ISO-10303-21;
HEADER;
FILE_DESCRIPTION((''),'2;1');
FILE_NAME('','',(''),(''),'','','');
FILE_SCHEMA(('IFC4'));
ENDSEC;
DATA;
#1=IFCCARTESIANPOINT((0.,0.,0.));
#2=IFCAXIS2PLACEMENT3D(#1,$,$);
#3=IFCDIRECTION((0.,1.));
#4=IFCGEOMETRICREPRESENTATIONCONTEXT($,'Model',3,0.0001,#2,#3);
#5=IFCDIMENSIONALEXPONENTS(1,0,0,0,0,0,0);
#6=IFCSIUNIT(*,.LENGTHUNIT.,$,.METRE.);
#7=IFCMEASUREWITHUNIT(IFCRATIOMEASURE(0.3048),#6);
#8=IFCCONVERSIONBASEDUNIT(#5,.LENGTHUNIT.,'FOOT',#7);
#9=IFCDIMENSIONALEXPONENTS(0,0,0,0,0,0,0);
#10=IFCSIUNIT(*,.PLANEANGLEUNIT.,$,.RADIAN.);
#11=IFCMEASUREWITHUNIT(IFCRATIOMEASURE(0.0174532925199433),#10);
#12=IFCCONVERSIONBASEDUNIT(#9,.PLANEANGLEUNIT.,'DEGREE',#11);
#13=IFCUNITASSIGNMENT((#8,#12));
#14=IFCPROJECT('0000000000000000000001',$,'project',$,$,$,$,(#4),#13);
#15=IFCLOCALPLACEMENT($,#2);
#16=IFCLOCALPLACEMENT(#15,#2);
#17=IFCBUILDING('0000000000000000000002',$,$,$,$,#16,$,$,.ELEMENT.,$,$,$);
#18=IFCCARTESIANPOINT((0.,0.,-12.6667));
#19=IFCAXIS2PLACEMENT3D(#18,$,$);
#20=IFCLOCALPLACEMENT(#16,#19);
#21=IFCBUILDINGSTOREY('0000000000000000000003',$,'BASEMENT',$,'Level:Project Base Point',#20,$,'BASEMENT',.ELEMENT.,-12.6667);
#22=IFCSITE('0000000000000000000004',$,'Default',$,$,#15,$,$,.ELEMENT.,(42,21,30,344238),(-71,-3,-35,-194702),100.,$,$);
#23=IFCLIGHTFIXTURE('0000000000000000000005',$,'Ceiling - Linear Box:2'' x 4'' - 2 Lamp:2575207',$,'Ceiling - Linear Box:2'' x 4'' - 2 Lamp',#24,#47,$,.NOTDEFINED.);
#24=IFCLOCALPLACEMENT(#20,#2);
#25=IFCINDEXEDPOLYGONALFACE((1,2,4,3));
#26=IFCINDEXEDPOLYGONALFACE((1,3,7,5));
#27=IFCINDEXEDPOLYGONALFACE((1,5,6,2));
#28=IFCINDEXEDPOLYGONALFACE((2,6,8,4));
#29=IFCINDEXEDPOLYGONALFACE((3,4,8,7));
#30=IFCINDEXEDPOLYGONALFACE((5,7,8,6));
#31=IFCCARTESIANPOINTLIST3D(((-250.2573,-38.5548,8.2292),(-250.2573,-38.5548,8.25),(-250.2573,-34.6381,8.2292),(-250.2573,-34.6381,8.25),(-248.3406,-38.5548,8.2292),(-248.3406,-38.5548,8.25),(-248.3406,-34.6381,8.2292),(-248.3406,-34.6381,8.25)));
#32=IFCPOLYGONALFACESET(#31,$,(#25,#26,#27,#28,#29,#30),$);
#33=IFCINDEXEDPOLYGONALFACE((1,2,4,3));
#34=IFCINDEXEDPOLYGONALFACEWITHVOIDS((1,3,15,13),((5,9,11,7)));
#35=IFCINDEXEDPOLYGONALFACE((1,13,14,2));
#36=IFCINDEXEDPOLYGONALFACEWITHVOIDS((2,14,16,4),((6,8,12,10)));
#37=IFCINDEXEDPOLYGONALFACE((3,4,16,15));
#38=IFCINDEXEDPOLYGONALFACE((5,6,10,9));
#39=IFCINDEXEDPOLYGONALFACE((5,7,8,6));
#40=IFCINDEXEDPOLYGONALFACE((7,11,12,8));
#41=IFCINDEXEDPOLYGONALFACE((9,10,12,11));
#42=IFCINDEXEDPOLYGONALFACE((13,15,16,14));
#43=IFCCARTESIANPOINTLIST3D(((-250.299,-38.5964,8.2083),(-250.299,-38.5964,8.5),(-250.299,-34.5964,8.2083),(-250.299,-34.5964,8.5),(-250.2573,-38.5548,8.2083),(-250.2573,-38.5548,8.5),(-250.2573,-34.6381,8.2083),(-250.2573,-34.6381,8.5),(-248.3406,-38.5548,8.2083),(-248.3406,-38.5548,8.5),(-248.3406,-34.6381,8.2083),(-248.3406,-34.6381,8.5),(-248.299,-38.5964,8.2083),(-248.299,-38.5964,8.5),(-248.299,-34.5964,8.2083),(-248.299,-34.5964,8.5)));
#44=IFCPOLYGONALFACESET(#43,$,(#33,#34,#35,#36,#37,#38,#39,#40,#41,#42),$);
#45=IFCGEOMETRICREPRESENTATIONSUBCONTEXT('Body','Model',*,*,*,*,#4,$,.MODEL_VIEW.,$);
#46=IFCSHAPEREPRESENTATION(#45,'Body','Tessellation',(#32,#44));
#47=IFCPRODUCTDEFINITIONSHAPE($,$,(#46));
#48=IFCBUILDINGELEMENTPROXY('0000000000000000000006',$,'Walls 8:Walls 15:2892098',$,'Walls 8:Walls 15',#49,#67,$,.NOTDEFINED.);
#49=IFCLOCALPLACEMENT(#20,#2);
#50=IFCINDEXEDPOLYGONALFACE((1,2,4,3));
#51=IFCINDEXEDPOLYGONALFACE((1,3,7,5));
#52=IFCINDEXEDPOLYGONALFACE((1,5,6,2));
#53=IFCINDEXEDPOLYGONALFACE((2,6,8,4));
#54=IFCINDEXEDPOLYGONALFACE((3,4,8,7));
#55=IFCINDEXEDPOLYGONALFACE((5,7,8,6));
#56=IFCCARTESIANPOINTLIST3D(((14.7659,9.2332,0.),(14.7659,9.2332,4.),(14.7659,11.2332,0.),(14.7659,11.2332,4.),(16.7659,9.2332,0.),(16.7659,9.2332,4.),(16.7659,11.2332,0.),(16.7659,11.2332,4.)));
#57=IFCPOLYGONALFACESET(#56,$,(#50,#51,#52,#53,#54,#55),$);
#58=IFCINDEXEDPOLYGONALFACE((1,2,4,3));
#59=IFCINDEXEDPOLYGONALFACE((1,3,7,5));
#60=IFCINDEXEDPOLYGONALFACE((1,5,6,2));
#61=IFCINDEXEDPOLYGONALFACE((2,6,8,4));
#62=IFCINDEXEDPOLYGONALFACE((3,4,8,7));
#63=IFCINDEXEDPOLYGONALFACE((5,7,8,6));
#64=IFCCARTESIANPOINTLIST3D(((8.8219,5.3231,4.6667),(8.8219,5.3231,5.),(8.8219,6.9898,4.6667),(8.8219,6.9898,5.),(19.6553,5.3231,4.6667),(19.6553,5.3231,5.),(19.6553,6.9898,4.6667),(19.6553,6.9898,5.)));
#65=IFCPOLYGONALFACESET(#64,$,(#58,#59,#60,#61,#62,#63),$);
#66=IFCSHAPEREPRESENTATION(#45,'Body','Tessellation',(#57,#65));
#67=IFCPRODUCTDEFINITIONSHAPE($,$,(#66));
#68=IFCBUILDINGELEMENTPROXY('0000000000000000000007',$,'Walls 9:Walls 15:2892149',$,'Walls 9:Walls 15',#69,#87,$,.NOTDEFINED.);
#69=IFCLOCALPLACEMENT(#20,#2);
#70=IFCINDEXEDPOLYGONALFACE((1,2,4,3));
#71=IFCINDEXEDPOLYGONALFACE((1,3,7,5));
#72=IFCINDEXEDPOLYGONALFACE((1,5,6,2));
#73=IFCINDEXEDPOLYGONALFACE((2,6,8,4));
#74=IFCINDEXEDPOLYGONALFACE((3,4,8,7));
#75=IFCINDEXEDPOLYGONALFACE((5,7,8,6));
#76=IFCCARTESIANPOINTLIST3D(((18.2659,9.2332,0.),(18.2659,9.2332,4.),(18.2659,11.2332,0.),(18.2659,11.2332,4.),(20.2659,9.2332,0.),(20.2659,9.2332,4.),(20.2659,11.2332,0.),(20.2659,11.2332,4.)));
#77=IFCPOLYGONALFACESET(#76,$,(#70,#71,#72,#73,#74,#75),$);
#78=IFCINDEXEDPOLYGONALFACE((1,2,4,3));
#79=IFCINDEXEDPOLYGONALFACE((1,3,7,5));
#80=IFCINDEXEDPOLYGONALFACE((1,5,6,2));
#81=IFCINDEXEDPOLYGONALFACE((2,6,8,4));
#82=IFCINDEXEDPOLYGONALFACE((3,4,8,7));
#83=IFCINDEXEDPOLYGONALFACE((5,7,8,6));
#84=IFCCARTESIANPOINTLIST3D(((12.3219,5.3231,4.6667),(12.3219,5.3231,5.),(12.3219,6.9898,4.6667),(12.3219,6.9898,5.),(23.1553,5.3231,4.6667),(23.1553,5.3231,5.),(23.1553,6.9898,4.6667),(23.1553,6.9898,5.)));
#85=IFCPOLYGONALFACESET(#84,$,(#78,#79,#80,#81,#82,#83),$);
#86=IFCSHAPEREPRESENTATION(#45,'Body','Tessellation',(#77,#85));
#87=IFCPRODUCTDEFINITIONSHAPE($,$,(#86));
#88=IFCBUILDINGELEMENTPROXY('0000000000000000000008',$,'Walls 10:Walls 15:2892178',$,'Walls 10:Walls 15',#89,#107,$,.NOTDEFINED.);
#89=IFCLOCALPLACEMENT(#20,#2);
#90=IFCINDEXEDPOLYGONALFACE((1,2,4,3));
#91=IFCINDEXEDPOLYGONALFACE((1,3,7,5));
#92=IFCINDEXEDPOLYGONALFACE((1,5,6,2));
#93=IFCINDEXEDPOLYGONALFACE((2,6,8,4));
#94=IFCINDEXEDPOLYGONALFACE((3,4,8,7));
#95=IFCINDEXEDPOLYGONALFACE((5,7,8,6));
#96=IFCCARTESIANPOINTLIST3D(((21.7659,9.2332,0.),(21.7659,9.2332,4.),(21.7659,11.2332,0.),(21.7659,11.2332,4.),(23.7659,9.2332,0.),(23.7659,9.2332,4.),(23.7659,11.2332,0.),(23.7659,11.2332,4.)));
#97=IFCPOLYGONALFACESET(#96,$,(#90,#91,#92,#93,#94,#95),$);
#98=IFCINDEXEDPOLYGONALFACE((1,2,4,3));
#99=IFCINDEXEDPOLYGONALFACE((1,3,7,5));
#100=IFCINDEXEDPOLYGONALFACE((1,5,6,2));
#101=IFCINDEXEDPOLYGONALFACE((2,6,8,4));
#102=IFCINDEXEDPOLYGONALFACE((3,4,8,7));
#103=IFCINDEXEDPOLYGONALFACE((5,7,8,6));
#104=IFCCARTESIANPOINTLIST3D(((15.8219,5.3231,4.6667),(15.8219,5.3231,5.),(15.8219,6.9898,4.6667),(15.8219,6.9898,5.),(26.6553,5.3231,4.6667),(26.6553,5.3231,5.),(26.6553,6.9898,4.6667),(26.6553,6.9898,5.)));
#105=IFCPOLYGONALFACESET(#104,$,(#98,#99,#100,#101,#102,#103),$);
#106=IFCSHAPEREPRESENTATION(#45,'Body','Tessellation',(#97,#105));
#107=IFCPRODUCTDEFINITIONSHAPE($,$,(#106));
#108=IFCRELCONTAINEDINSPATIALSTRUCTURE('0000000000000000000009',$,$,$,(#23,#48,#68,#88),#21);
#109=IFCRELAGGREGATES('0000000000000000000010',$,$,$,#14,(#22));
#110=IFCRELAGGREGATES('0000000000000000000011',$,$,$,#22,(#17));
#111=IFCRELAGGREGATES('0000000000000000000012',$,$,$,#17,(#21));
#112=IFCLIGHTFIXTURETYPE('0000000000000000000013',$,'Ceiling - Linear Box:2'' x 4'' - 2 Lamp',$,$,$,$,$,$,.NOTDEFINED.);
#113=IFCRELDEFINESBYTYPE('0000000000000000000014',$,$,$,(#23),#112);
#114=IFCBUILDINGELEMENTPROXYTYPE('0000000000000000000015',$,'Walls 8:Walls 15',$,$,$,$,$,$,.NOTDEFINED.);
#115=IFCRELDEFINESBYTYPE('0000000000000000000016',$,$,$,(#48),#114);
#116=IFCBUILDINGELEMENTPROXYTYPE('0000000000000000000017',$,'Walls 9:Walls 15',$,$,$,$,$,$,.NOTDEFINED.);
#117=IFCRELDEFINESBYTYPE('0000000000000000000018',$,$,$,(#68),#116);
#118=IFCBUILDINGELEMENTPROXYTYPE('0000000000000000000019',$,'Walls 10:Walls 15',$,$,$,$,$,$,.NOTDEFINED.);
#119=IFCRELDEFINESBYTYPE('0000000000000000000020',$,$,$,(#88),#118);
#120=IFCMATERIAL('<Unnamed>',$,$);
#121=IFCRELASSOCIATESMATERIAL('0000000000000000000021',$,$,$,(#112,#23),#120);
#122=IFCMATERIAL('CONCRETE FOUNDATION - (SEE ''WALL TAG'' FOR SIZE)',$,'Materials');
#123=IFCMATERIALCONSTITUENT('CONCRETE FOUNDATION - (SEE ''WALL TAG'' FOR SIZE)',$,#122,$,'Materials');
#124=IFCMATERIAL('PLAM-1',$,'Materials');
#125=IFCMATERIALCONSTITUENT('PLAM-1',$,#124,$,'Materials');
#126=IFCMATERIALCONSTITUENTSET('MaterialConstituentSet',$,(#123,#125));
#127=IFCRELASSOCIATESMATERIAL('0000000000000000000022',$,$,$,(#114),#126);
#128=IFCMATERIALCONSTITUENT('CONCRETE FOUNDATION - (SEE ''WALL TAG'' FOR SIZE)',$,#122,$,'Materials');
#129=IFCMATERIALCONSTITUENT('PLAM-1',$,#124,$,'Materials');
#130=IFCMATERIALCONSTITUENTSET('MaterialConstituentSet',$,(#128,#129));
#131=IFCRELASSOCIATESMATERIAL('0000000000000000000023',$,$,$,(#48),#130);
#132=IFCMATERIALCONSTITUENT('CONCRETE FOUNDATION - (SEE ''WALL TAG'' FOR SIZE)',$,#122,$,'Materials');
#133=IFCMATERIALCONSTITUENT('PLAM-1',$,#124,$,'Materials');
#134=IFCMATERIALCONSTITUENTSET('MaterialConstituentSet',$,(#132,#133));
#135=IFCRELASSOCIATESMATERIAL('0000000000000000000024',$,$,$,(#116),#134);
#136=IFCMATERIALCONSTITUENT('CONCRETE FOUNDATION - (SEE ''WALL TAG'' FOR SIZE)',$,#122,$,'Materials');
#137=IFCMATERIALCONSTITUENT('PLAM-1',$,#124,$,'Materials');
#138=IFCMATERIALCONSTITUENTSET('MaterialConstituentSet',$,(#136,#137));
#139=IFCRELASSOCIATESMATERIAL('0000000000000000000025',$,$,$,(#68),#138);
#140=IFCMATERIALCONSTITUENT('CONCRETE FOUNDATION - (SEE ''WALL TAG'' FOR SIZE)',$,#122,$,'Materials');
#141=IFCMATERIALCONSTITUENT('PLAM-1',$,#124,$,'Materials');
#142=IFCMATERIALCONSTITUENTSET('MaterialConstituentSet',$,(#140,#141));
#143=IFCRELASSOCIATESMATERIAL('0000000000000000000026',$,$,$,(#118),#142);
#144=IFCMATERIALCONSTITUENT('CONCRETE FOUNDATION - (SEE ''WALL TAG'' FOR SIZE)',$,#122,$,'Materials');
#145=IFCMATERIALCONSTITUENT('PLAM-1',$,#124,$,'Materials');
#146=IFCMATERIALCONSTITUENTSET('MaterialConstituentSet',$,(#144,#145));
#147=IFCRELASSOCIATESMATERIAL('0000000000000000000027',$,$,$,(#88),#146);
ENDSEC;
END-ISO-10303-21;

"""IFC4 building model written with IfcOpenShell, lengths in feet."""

from ifc_helpers import new_model, entity, si_unit, converted_unit, direction, frame, frame_2d, origin, origin_2d_with_axis, place, context, subcontext, project, spatial, polyline, rectangle, outline, extrude, source, transform, mapped, material, constituent, constituent_set, type_object, type_shapes, element, save


model = new_model("IFC4")

# Units and contexts
model_context = context("Model", 3, precision=0.0001, world=origin(), true_north=direction((0.0, 1.0)))
body_context = subcontext(model_context, "Body", "Model", "MODEL_VIEW")
ifc_project = project(units=[converted_unit("LENGTHUNIT", "FOOT", entity("IfcRatioMeasure", 0.3048), si_unit("LENGTHUNIT", "METRE"), dimensions=[1, 0, 0, 0, 0, 0, 0]), converted_unit("PLANEANGLEUNIT", "DEGREE", entity("IfcRatioMeasure", 0.0174532925199433), si_unit("PLANEANGLEUNIT", "RADIAN"), dimensions=[0, 0, 0, 0, 0, 0, 0])], contexts=[model_context])

# Site, building, storey
site_placement = place(None, origin())
site = spatial("IfcSite", under=ifc_project, at=site_placement, Name="Default", CompositionType="ELEMENT", RefLatitude=(42, 21, 30, 344238), RefLongitude=(-71, -3, -35, -194702), RefElevation=100.0)
building_placement = place(site_placement, origin())
building = spatial("IfcBuilding", under=site, at=building_placement, CompositionType="ELEMENT")
storey_placement = place(building_placement, frame((0.0, 0.0, -12.6667)))
storey = spatial("IfcBuildingStorey", under=building, at=storey_placement, Name="BASEMENT", ObjectType="Level:Project Base Point", LongName="BASEMENT", CompositionType="ELEMENT", Elevation=-12.6667)

# Shared definitions
ifc_material_1 = material(Name="CONCRETE FOUNDATION - (SEE 'WALL TAG' FOR SIZE)", Category="Materials")
ifc_material_2 = material(Name="PLAM-1", Category="Materials")

# Light fixture
ifc_material_3 = material(Name="<Unnamed>")
light_fixture_type_1 = type_object("IfcLightFixtureType", Name="Ceiling - Linear Box:2' x 4' - 2 Lamp", PredefinedType="NOTDEFINED", material=ifc_material_3)
shared_shape_1 = source(origin(), body_context, "Body", "SweptSolid", [
    extrude(rectangle(XDim=3.9167, YDim=1.9167, at=origin_2d_with_axis()), frame((2.0, 1.0, 0.0208), z_axis=(0.0, 0.0, 1.0), x_axis=(-1.0, 0.0, 0.0)), (0.0, 0.0, 1.0), 0.0208),
    extrude(outline(polyline([(-2.0, -1.0), (2.0, -1.0), (2.0, 1.0), (-2.0, 1.0), (-2.0, -1.0)]), holes=[polyline([(-1.9583, -0.9583), (-1.9583, 0.9583), (1.9583, 0.9583), (1.9583, -0.9583), (-1.9583, -0.9583)])]), frame((2.0, 1.0, 0.0), z_axis=(0.0, 0.0, 1.0), x_axis=(-1.0, 0.0, 0.0)), (0.0, 0.0, 1.0), 0.2917),
])
type_shapes(light_fixture_type_1, [shared_shape_1])
light_fixture_1_placement = place(storey_placement, frame((-248.299, -38.5964, 8.2083), z_axis=(0.0, 0.0, 1.0), x_axis=(0.0, 1.0, 0.0)))
element("IfcLightFixture", 1, at=light_fixture_1_placement, inside=storey, type_object=light_fixture_type_1, material=ifc_material_3, Name="Ceiling - Linear Box:2' x 4' - 2 Lamp:2575207", ObjectType="Ceiling - Linear Box:2' x 4' - 2 Lamp", PredefinedType="NOTDEFINED", context=body_context, shape_type="MappedRepresentation", body=[
    mapped(shared_shape_1, transform((0.0, 0.0, 0.0), scale=1.0)),
])

# Building element proxies
ifc_constituent_1 = constituent(ifc_material_1, Name="CONCRETE FOUNDATION - (SEE 'WALL TAG' FOR SIZE)", Category="Materials")
ifc_constituent_2 = constituent(ifc_material_2, Name="PLAM-1", Category="Materials")
ifc_constituent_set_1 = constituent_set(constituents=[ifc_constituent_1, ifc_constituent_2], Name="MaterialConstituentSet")
ifc_constituent_3 = constituent(ifc_material_1, Name="CONCRETE FOUNDATION - (SEE 'WALL TAG' FOR SIZE)", Category="Materials")
ifc_constituent_4 = constituent(ifc_material_2, Name="PLAM-1", Category="Materials")
ifc_constituent_set_2 = constituent_set(constituents=[ifc_constituent_3, ifc_constituent_4], Name="MaterialConstituentSet")
building_element_proxy_type_1 = type_object("IfcBuildingElementProxyType", Name="Walls 8:Walls 15", PredefinedType="NOTDEFINED", material=ifc_constituent_set_2)
shared_shape_2 = source(origin(), body_context, "Body", "SweptSolid", [
    extrude(rectangle(XDim=2.0, YDim=2.0, at=origin_2d_with_axis()), frame((6.944, 4.9101, 0.0), z_axis=(0.0, 0.0, 1.0), x_axis=(-1.0, 0.0, 0.0)), (0.0, 0.0, 1.0), 4.0),
    extrude(rectangle(XDim=10.8333, YDim=1.6667, at=frame_2d((0.0, 0.0), x_axis=(1.0, 0.0))), frame((5.4167, 0.8333, 4.6667), z_axis=(0.0, 0.0, 1.0), x_axis=(-1.0, 0.0, 0.0)), (0.0, 0.0, 1.0), 0.3333),
])
type_shapes(building_element_proxy_type_1, [shared_shape_2])
proxy_1_placement = place(storey_placement, frame((8.8219, 5.3231, 0.0)))
element("IfcBuildingElementProxy", 2, at=proxy_1_placement, inside=storey, type_object=building_element_proxy_type_1, material=ifc_constituent_set_1, Name="Walls 8:Walls 15:2892098", ObjectType="Walls 8:Walls 15", PredefinedType="NOTDEFINED", context=body_context, shape_type="MappedRepresentation", body=[
    mapped(shared_shape_2, transform((0.0, 0.0, 0.0), scale=1.0)),
])
ifc_constituent_5 = constituent(ifc_material_1, Name="CONCRETE FOUNDATION - (SEE 'WALL TAG' FOR SIZE)", Category="Materials")
ifc_constituent_6 = constituent(ifc_material_2, Name="PLAM-1", Category="Materials")
ifc_constituent_set_3 = constituent_set(constituents=[ifc_constituent_5, ifc_constituent_6], Name="MaterialConstituentSet")
ifc_constituent_7 = constituent(ifc_material_1, Name="CONCRETE FOUNDATION - (SEE 'WALL TAG' FOR SIZE)", Category="Materials")
ifc_constituent_8 = constituent(ifc_material_2, Name="PLAM-1", Category="Materials")
ifc_constituent_set_4 = constituent_set(constituents=[ifc_constituent_7, ifc_constituent_8], Name="MaterialConstituentSet")
building_element_proxy_type_2 = type_object("IfcBuildingElementProxyType", Name="Walls 9:Walls 15", PredefinedType="NOTDEFINED", material=ifc_constituent_set_4)
shared_shape_3 = source(origin(), body_context, "Body", "SweptSolid", [
    extrude(rectangle(XDim=2.0, YDim=2.0, at=origin_2d_with_axis()), frame((6.944, 4.9101, 0.0), z_axis=(0.0, 0.0, 1.0), x_axis=(-1.0, 0.0, 0.0)), (0.0, 0.0, 1.0), 4.0),
    extrude(rectangle(XDim=10.8333, YDim=1.6667, at=frame_2d((0.0, 0.0), x_axis=(1.0, 0.0))), frame((5.4167, 0.8333, 4.6667), z_axis=(0.0, 0.0, 1.0), x_axis=(-1.0, 0.0, 0.0)), (0.0, 0.0, 1.0), 0.3333),
])
type_shapes(building_element_proxy_type_2, [shared_shape_3])
proxy_2_placement = place(storey_placement, frame((12.3219, 5.3231, 0.0)))
element("IfcBuildingElementProxy", 3, at=proxy_2_placement, inside=storey, type_object=building_element_proxy_type_2, material=ifc_constituent_set_3, Name="Walls 9:Walls 15:2892149", ObjectType="Walls 9:Walls 15", PredefinedType="NOTDEFINED", context=body_context, shape_type="MappedRepresentation", body=[
    mapped(shared_shape_3, transform((0.0, 0.0, 0.0), scale=1.0)),
])
ifc_constituent_9 = constituent(ifc_material_1, Name="CONCRETE FOUNDATION - (SEE 'WALL TAG' FOR SIZE)", Category="Materials")
ifc_constituent_10 = constituent(ifc_material_2, Name="PLAM-1", Category="Materials")
ifc_constituent_set_5 = constituent_set(constituents=[ifc_constituent_9, ifc_constituent_10], Name="MaterialConstituentSet")
ifc_constituent_11 = constituent(ifc_material_1, Name="CONCRETE FOUNDATION - (SEE 'WALL TAG' FOR SIZE)", Category="Materials")
ifc_constituent_12 = constituent(ifc_material_2, Name="PLAM-1", Category="Materials")
ifc_constituent_set_6 = constituent_set(constituents=[ifc_constituent_11, ifc_constituent_12], Name="MaterialConstituentSet")
building_element_proxy_type_3 = type_object("IfcBuildingElementProxyType", Name="Walls 10:Walls 15", PredefinedType="NOTDEFINED", material=ifc_constituent_set_6)
shared_shape_4 = source(origin(), body_context, "Body", "SweptSolid", [
    extrude(rectangle(XDim=2.0, YDim=2.0, at=origin_2d_with_axis()), frame((6.944, 4.9101, 0.0), z_axis=(0.0, 0.0, 1.0), x_axis=(-1.0, 0.0, 0.0)), (0.0, 0.0, 1.0), 4.0),
    extrude(rectangle(XDim=10.8333, YDim=1.6667, at=frame_2d((0.0, 0.0), x_axis=(1.0, 0.0))), frame((5.4167, 0.8333, 4.6667), z_axis=(0.0, 0.0, 1.0), x_axis=(-1.0, 0.0, 0.0)), (0.0, 0.0, 1.0), 0.3333),
])
type_shapes(building_element_proxy_type_3, [shared_shape_4])
proxy_3_placement = place(storey_placement, frame((15.8219, 5.3231, 0.0)))
element("IfcBuildingElementProxy", 4, at=proxy_3_placement, inside=storey, type_object=building_element_proxy_type_3, material=ifc_constituent_set_5, Name="Walls 10:Walls 15:2892178", ObjectType="Walls 10:Walls 15", PredefinedType="NOTDEFINED", context=body_context, shape_type="MappedRepresentation", body=[
    mapped(shared_shape_4, transform((0.0, 0.0, 0.0), scale=1.0)),
])

save(model, "model.ifc")
